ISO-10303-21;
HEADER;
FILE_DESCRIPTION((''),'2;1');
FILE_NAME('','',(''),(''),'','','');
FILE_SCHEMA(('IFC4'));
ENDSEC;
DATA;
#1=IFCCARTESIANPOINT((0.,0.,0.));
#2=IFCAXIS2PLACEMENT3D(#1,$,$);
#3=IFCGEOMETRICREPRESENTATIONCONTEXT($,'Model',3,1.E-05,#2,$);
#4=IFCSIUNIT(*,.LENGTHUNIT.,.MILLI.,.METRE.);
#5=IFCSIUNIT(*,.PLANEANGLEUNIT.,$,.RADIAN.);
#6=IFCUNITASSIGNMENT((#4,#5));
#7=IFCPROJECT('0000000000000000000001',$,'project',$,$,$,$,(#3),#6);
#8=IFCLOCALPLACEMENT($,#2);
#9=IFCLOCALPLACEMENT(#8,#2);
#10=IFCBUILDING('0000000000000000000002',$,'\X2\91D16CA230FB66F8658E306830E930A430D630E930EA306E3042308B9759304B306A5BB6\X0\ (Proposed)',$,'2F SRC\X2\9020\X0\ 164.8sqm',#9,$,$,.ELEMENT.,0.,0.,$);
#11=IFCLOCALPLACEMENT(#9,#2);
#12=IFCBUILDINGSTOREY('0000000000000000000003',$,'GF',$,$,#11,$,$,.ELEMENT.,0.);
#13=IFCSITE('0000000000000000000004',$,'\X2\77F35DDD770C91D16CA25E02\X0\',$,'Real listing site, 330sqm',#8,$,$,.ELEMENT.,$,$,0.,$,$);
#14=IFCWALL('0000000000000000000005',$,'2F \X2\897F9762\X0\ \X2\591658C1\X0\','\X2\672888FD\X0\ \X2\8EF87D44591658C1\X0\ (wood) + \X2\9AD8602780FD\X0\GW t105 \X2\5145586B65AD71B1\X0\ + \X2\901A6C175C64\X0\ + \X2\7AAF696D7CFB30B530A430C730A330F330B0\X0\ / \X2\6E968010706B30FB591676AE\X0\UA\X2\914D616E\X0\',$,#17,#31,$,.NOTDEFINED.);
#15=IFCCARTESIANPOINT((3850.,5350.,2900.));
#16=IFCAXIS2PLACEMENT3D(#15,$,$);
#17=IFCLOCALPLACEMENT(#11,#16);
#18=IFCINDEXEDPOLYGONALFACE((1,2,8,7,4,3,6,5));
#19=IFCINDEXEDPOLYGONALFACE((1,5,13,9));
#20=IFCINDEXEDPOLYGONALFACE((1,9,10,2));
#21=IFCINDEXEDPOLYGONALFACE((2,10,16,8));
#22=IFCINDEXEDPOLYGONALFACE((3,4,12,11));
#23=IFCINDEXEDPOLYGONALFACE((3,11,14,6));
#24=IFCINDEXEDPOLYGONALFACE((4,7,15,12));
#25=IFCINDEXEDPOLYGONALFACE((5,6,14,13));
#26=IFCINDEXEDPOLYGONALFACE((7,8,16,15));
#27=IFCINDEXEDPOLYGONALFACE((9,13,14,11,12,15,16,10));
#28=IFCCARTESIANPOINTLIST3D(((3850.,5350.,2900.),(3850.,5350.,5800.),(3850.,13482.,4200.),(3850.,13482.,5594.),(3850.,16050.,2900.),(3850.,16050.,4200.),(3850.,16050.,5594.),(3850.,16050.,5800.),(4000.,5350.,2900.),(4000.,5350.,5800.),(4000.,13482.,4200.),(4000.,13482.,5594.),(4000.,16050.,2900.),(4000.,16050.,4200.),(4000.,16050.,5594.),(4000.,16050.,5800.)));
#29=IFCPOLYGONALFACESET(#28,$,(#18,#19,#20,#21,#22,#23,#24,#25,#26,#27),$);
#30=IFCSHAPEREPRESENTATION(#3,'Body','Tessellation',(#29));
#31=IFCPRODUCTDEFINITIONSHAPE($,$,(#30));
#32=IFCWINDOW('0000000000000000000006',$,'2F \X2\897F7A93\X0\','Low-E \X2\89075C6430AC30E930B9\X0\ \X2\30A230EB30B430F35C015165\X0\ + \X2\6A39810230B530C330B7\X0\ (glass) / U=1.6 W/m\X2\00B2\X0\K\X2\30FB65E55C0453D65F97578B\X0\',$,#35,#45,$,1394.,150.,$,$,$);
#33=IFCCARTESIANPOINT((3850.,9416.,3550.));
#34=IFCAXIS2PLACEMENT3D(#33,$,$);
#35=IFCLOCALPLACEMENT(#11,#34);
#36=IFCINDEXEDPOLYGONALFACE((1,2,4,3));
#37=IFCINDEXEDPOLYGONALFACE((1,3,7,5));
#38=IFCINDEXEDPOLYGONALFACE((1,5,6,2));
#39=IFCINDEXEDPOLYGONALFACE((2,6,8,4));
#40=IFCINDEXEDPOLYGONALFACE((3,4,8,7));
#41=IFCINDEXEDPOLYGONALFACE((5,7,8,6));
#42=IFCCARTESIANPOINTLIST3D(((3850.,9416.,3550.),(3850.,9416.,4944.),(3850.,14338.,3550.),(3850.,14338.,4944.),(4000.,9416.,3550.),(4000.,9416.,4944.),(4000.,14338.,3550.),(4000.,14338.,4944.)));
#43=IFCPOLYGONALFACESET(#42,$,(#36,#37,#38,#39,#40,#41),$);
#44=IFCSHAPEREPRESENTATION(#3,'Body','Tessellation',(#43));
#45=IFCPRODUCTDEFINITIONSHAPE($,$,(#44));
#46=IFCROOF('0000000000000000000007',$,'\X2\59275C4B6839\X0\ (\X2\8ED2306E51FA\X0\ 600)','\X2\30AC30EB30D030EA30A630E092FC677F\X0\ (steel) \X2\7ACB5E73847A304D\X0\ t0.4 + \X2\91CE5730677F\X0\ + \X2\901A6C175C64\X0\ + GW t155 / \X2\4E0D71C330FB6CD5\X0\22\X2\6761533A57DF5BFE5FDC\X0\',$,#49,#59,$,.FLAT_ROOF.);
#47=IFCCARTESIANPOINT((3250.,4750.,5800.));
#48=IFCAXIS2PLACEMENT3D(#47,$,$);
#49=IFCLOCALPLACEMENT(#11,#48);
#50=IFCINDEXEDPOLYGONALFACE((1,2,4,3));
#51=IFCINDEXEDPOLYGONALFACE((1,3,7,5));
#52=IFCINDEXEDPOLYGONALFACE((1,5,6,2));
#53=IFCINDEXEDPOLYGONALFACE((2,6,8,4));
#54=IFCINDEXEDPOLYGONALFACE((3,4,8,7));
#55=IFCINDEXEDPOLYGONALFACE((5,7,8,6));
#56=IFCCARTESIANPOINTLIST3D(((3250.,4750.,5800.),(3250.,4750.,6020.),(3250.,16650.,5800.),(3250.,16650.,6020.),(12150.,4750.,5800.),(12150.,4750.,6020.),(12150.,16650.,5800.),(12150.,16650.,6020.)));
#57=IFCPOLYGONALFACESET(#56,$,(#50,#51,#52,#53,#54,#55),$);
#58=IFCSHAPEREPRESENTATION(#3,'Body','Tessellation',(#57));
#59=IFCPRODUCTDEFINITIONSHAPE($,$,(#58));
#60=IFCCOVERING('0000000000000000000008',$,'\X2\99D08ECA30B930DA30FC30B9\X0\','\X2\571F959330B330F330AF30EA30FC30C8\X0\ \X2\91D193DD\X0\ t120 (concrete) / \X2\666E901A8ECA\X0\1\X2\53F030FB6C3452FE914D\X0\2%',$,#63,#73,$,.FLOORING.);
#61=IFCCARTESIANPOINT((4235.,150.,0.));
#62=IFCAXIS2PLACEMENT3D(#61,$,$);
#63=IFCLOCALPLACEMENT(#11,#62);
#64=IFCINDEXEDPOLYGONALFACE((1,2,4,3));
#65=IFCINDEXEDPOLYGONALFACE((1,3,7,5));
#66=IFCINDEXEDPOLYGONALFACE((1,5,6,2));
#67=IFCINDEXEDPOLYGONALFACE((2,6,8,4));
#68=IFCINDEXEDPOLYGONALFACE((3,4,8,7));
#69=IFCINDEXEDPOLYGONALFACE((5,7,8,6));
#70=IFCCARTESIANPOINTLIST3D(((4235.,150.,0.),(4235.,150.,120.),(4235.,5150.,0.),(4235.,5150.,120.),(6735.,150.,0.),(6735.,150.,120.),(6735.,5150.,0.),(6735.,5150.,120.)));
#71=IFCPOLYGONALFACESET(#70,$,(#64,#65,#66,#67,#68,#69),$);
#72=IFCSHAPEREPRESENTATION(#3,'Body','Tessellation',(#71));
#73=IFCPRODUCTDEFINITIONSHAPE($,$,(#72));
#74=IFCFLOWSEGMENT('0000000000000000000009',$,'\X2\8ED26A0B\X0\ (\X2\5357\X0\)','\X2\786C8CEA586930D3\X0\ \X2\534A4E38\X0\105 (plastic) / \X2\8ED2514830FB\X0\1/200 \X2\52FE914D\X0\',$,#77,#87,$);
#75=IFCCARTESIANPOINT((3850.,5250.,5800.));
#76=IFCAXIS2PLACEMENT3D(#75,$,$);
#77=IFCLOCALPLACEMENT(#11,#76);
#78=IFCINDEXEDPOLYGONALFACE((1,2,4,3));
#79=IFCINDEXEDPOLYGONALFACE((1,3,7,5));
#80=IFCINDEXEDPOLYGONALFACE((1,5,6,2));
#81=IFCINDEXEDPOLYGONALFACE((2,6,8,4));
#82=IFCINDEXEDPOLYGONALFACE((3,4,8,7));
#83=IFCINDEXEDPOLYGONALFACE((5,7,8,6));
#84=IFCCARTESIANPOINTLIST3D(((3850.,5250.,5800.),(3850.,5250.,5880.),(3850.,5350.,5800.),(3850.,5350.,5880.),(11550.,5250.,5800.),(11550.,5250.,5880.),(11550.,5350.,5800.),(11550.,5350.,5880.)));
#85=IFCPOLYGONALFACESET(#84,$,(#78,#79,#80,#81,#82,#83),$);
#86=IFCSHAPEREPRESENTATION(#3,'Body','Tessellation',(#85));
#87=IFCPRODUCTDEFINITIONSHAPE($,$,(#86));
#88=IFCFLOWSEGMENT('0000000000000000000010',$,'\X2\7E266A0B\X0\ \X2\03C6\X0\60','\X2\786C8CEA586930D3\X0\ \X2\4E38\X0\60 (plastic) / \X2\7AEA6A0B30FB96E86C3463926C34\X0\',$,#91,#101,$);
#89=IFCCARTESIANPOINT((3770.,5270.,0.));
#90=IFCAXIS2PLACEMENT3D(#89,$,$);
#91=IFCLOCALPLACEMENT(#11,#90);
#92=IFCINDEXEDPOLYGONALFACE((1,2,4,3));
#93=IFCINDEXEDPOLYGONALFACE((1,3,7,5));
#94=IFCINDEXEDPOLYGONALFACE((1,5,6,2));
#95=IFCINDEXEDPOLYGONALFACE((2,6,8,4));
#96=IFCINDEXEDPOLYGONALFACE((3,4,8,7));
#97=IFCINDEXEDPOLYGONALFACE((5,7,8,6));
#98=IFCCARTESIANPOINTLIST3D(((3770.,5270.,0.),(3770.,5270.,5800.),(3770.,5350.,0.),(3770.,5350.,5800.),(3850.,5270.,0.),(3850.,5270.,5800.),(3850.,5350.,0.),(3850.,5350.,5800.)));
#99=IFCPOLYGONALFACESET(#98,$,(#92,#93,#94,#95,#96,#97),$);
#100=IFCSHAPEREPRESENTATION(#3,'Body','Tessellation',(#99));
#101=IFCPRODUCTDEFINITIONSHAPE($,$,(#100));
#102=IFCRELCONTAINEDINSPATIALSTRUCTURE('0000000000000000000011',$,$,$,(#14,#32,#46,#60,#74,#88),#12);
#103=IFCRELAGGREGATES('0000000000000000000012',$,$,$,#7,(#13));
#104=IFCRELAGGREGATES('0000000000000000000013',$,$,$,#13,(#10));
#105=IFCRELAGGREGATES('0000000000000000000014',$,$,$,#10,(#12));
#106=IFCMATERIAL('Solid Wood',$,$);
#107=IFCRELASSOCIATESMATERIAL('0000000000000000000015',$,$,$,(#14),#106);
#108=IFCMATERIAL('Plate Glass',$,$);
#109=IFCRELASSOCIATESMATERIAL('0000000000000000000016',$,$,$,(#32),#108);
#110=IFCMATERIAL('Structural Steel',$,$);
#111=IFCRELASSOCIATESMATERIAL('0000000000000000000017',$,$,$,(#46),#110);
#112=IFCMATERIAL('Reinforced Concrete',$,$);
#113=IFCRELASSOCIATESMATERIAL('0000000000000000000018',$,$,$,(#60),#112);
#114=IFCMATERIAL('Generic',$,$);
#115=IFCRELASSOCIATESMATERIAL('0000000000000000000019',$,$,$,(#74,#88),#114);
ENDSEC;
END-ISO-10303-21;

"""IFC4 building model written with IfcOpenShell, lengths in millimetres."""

from ifc_helpers import new_model, si_unit, frame, frame_2d, origin, place, context, project, spatial, rectangle, extrude, material, element, fill, save


model = new_model("IFC4")

# Units and contexts
model_context = context("Model", 3, precision=1e-05, world=origin())
ifc_project = project(units=[si_unit("LENGTHUNIT", "METRE", prefix="MILLI"), si_unit("PLANEANGLEUNIT", "RADIAN")], contexts=[model_context])

# Site, building, storey
site_placement = place(None, origin())
site = spatial("IfcSite", under=ifc_project, at=site_placement, Name="石川県金沢市", ObjectType="Real listing site, 330sqm", CompositionType="ELEMENT", RefElevation=0.0)
building_placement = place(site_placement, origin())
building = spatial("IfcBuilding", under=site, at=building_placement, Name="金沢・書斎とライブラリのある静かな家 (Proposed)", ObjectType="2F SRC造 164.8sqm", CompositionType="ELEMENT", ElevationOfRefHeight=0.0, ElevationOfTerrain=0.0)
storey_placement = place(building_placement, origin())
storey = spatial("IfcBuildingStorey", under=building, at=storey_placement, Name="GF", CompositionType="ELEMENT", Elevation=0.0)

# Shared definitions
ifc_material_1 = material(Name="Solid Wood")

# Shared definitions
ifc_material_2 = material(Name="Reinforced Concrete")

# Shared definitions
ifc_material_3 = material(Name="Plate Glass")

# Wall, opening, window
wall_1_placement = place(storey_placement, frame((3850.0, 5350.0, 2900.0)))
wall_1 = element("IfcWall", 1, at=wall_1_placement, inside=storey, material=ifc_material_1, Name="2F 西面 外壁", Description="木製 軸組外壁 (wood) + 高性能GW t105 充填断熱 + 通気層 + 窯業系サイディング / 準耐火・外皮UA配慮", PredefinedType="NOTDEFINED", context=model_context, shape_type="SweptSolid", body=[
    extrude(rectangle(XDim=150.0, YDim=10700.0, at=frame_2d((75.0, 5350.0))), frame((3850.0, 5350.0, 2900.0)), (0.0, 0.0, 1.0), 2900.0),
])
opening_1_placement = place(storey_placement, frame((3850.0, 9416.0, 3550.0)))
opening_1 = element("IfcOpeningElement", 2, at=opening_1_placement, cuts=wall_1, PredefinedType="NOTDEFINED", context=model_context, shape_type="SweptSolid", body=[
    extrude(rectangle(XDim=150.0, YDim=4922.0, at=frame_2d((75.0, 2461.0))), frame((3850.0, 9416.0, 3550.0)), (0.0, 0.0, 1.0), 1394.0),
])
window_1_placement = place(storey_placement, frame((3850.0, 9416.0, 3550.0)))
window_1 = element("IfcWindow", 3, at=window_1_placement, inside=storey, material=ifc_material_3, Name="2F 西窓", Description="Low-E 複層ガラス アルゴン封入 + 樹脂サッシ (glass) / U=1.6 W/m²K・日射取得型", OverallHeight=1394.0, OverallWidth=150.0, context=model_context, shape_type="SweptSolid", body=[
    extrude(rectangle(XDim=150.0, YDim=4922.0, at=frame_2d((75.0, 2461.0))), frame((3850.0, 9416.0, 3550.0)), (0.0, 0.0, 1.0), 1394.0),
])
fill(opening_1, window_1)

# Roof
ifc_material_4 = material(Name="Structural Steel")
roof_placement = place(storey_placement, frame((3250.0, 4750.0, 5800.0)))
element("IfcRoof", 4, at=roof_placement, inside=storey, material=ifc_material_4, Name="大屋根 (軒の出 600)", Description="ガルバリウム鋼板 (steel) 立平葺き t0.4 + 野地板 + 通気層 + GW t155 / 不燃・法22条区域対応", PredefinedType="FLAT_ROOF", context=model_context, shape_type="SweptSolid", body=[
    extrude(rectangle(XDim=8900.0, YDim=11900.0, at=frame_2d((4450.0, 5950.0))), frame((3250.0, 4750.0, 5800.0)), (0.0, 0.0, 1.0), 220.0),
])

# Covering
covering_placement = place(storey_placement, frame((4235.0, 150.0, 0.0)))
element("IfcCovering", 5, at=covering_placement, inside=storey, material=ifc_material_2, Name="駐車スペース", Description="土間コンクリート 金鏝 t120 (concrete) / 普通車1台・水勾配2%", PredefinedType="FLOORING", context=model_context, shape_type="SweptSolid", body=[
    extrude(rectangle(XDim=2500.0, YDim=5000.0, at=frame_2d((1250.0, 2500.0))), frame((4235.0, 150.0, 0.0)), (0.0, 0.0, 1.0), 120.0),
])

# Flow segments
ifc_material_5 = material(Name="Generic")
flow_segment_1_placement = place(storey_placement, frame((3850.0, 5250.0, 5800.0)))
element("IfcFlowSegment", 6, at=flow_segment_1_placement, inside=storey, material=ifc_material_5, Name="軒樋 (南)", Description="硬質塩ビ 半丸105 (plastic) / 軒先・1/200 勾配", context=model_context, shape_type="SweptSolid", body=[
    extrude(rectangle(XDim=7700.0, YDim=100.0, at=frame_2d((3850.0, 50.0))), frame((3850.0, 5250.0, 5800.0)), (0.0, 0.0, 1.0), 80.0),
])
flow_segment_2_placement = place(storey_placement, frame((3770.0, 5270.0, 0.0)))
element("IfcFlowSegment", 7, at=flow_segment_2_placement, inside=storey, material=ifc_material_5, Name="縦樋 φ60", Description="硬質塩ビ 丸60 (plastic) / 竪樋・雨水排水", context=model_context, shape_type="SweptSolid", body=[
    extrude(rectangle(XDim=80.0, YDim=80.0, at=frame_2d((40.0, 40.0))), frame((3770.0, 5270.0, 0.0)), (0.0, 0.0, 1.0), 5800.0),
])

save(model, "model.ifc")
